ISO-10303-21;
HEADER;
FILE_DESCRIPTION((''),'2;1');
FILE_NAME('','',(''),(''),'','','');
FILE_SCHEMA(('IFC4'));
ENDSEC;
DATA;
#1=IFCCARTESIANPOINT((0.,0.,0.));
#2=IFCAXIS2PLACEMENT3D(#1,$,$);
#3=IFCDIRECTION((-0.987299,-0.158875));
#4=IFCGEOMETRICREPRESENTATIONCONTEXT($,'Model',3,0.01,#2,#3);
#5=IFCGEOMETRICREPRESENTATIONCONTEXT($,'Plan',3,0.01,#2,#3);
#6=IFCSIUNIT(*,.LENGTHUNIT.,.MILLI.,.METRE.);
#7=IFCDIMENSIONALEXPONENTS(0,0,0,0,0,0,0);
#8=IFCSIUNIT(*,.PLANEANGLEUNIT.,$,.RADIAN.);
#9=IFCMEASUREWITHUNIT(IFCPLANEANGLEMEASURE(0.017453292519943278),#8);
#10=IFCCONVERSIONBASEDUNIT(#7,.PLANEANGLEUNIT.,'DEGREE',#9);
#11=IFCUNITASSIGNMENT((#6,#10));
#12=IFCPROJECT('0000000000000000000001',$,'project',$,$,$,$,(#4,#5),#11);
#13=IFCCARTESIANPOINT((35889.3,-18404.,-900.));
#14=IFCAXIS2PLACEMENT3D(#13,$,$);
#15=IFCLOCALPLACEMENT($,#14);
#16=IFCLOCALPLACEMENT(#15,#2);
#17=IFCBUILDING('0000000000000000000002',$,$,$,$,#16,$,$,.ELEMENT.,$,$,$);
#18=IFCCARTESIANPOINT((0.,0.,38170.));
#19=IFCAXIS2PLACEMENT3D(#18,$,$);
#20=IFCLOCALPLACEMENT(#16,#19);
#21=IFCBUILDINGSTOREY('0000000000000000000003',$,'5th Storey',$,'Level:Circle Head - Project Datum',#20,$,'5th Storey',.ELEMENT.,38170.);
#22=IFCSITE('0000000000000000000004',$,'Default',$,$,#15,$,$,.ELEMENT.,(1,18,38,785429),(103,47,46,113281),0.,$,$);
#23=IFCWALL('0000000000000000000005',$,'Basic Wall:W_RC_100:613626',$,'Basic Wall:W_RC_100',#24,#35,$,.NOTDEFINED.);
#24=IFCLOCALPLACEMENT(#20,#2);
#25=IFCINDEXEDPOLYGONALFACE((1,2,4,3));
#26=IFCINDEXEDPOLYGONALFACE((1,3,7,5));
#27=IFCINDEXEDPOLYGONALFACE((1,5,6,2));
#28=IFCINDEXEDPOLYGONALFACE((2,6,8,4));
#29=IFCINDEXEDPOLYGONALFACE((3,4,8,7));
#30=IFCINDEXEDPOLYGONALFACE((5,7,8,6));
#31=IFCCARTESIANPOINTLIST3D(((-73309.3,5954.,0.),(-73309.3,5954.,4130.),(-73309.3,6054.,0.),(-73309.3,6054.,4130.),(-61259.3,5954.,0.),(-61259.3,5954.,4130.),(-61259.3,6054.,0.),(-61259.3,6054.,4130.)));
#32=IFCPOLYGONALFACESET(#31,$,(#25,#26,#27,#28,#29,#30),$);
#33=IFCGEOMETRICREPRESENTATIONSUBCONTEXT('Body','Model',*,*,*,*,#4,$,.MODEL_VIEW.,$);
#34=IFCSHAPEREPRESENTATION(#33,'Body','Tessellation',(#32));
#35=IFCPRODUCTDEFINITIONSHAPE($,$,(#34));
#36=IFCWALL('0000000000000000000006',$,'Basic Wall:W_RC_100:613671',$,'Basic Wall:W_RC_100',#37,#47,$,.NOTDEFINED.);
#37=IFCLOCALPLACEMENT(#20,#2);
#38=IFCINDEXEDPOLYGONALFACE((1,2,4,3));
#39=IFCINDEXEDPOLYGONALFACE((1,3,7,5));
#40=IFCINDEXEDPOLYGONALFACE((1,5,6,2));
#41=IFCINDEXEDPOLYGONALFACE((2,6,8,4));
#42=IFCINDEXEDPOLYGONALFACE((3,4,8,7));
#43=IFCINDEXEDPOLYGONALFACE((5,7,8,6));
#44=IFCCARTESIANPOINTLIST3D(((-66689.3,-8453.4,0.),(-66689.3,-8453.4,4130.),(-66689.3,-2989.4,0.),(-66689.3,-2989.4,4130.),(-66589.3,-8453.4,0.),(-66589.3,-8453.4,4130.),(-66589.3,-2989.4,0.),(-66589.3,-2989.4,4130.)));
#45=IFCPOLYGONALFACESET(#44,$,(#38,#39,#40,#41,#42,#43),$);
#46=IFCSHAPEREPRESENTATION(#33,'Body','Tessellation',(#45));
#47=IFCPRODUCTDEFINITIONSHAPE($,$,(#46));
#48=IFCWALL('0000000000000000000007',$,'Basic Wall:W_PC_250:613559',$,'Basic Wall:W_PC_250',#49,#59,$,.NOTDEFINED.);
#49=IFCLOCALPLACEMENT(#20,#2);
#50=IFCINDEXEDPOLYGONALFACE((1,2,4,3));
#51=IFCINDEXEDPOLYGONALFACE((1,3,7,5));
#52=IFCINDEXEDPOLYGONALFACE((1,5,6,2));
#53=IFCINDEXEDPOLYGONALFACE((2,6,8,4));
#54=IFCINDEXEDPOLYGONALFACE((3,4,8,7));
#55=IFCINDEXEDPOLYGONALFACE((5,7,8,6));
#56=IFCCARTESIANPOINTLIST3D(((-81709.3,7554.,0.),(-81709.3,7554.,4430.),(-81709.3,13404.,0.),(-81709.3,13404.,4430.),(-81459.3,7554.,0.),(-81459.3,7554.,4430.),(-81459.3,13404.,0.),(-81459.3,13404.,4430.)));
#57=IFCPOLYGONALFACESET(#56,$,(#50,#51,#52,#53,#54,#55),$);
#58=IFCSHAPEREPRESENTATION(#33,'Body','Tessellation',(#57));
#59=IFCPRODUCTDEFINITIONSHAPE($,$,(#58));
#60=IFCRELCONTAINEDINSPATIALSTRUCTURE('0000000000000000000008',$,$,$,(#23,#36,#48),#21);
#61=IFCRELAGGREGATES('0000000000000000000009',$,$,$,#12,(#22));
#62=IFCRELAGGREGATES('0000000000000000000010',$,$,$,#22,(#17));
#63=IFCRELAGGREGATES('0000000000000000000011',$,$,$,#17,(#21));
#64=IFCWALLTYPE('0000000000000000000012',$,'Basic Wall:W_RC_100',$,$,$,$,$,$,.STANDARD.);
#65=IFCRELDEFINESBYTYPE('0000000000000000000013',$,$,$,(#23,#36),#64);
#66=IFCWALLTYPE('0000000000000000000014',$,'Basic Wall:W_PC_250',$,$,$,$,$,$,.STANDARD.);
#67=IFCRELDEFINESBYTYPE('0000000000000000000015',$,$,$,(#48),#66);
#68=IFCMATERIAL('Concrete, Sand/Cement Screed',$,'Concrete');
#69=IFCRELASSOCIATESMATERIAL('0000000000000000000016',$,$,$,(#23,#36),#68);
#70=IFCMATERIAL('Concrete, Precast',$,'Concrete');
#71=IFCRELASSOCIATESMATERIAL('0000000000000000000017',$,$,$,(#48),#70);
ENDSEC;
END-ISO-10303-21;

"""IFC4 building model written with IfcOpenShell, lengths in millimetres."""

from ifc_helpers import new_model, entity, si_unit, converted_unit, direction, frame, origin, place, context, subcontext, project, spatial, indexed_curve, outline, extrude, material, type_object, element, save


model = new_model("IFC4")

# Units and contexts
model_context = context("Model", 3, precision=0.01, world=origin(), true_north=direction((-0.987299, -0.158875)))
plan_context = context("Plan", 3, precision=0.01, world=origin(), true_north=direction((-0.987299, -0.158875)))
body_context = subcontext(model_context, "Body", "Model", "MODEL_VIEW")
ifc_project = project(units=[si_unit("LENGTHUNIT", "METRE", prefix="MILLI"), converted_unit("PLANEANGLEUNIT", "DEGREE", entity("IfcPlaneAngleMeasure", 0.017453292519943278), si_unit("PLANEANGLEUNIT", "RADIAN"), dimensions=[0, 0, 0, 0, 0, 0, 0])], contexts=[model_context, plan_context])

# Site, building, storey
site_placement = place(None, frame((35889.3, -18404.0, -900.0)))
site = spatial("IfcSite", under=ifc_project, at=site_placement, Name="Default", CompositionType="ELEMENT", RefLatitude=(1, 18, 38, 785429), RefLongitude=(103, 47, 46, 113281), RefElevation=0.0)
building_placement = place(site_placement, origin())
building = spatial("IfcBuilding", under=site, at=building_placement, CompositionType="ELEMENT")
storey_placement = place(building_placement, frame((0.0, 0.0, 38170.0)))
storey = spatial("IfcBuildingStorey", under=building, at=storey_placement, Name="5th Storey", ObjectType="Level:Circle Head - Project Datum", LongName="5th Storey", CompositionType="ELEMENT", Elevation=38170.0)

# Walls
ifc_material_1 = material(Name="Concrete, Sand/Cement Screed", Category="Concrete")
wall_type_1 = type_object("IfcWallType", Name="Basic Wall:W_RC_100", PredefinedType="STANDARD")
wall_1_placement = place(storey_placement, frame((-73309.3, 6004.0, 0.0)))
element("IfcWall", 1, at=wall_1_placement, inside=storey, type_object=wall_type_1, material=ifc_material_1, Name="Basic Wall:W_RC_100:613626", ObjectType="Basic Wall:W_RC_100", PredefinedType="NOTDEFINED", context=body_context, shape_type="SweptSolid", body=[
    extrude(outline(indexed_curve([(12050.0, 50.0), (0.0, 50.0), (0.0, -50.0), (12050.0, -50.0), (12050.0, 50.0)], self_intersect=False)), origin(), (0.0, 0.0, 1.0), 4130.0),
])
wall_2_placement = place(storey_placement, frame((-66639.3, -2989.4, 0.0), z_axis=(0.0, 0.0, 1.0), x_axis=(0.0, -1.0, 0.0)))
element("IfcWall", 2, at=wall_2_placement, inside=storey, type_object=wall_type_1, material=ifc_material_1, Name="Basic Wall:W_RC_100:613671", ObjectType="Basic Wall:W_RC_100", PredefinedType="NOTDEFINED", context=body_context, shape_type="SweptSolid", body=[
    extrude(outline(indexed_curve([(5464.1, 50.0), (0.0, 50.0), (0.0, -50.0), (5464.1, -50.0), (5464.1, 50.0)], self_intersect=False)), origin(), (0.0, 0.0, 1.0), 4130.0),
])
ifc_material_2 = material(Name="Concrete, Precast", Category="Concrete")
wall_type_2 = type_object("IfcWallType", Name="Basic Wall:W_PC_250", PredefinedType="STANDARD")
wall_3_placement = place(storey_placement, frame((-81584.3, 7554.0, 0.0), z_axis=(0.0, 0.0, 1.0), x_axis=(0.0, 1.0, 0.0)))
element("IfcWall", 3, at=wall_3_placement, inside=storey, type_object=wall_type_2, material=ifc_material_2, Name="Basic Wall:W_PC_250:613559", ObjectType="Basic Wall:W_PC_250", PredefinedType="NOTDEFINED", context=body_context, shape_type="SweptSolid", body=[
    extrude(outline(indexed_curve([(5850.0, 125.0), (0.0, 125.0), (0.0, -125.0), (5850.0, -125.0), (5850.0, 125.0)], self_intersect=False)), origin(), (0.0, 0.0, 1.0), 4430.0),
])

save(model, "model.ifc")
